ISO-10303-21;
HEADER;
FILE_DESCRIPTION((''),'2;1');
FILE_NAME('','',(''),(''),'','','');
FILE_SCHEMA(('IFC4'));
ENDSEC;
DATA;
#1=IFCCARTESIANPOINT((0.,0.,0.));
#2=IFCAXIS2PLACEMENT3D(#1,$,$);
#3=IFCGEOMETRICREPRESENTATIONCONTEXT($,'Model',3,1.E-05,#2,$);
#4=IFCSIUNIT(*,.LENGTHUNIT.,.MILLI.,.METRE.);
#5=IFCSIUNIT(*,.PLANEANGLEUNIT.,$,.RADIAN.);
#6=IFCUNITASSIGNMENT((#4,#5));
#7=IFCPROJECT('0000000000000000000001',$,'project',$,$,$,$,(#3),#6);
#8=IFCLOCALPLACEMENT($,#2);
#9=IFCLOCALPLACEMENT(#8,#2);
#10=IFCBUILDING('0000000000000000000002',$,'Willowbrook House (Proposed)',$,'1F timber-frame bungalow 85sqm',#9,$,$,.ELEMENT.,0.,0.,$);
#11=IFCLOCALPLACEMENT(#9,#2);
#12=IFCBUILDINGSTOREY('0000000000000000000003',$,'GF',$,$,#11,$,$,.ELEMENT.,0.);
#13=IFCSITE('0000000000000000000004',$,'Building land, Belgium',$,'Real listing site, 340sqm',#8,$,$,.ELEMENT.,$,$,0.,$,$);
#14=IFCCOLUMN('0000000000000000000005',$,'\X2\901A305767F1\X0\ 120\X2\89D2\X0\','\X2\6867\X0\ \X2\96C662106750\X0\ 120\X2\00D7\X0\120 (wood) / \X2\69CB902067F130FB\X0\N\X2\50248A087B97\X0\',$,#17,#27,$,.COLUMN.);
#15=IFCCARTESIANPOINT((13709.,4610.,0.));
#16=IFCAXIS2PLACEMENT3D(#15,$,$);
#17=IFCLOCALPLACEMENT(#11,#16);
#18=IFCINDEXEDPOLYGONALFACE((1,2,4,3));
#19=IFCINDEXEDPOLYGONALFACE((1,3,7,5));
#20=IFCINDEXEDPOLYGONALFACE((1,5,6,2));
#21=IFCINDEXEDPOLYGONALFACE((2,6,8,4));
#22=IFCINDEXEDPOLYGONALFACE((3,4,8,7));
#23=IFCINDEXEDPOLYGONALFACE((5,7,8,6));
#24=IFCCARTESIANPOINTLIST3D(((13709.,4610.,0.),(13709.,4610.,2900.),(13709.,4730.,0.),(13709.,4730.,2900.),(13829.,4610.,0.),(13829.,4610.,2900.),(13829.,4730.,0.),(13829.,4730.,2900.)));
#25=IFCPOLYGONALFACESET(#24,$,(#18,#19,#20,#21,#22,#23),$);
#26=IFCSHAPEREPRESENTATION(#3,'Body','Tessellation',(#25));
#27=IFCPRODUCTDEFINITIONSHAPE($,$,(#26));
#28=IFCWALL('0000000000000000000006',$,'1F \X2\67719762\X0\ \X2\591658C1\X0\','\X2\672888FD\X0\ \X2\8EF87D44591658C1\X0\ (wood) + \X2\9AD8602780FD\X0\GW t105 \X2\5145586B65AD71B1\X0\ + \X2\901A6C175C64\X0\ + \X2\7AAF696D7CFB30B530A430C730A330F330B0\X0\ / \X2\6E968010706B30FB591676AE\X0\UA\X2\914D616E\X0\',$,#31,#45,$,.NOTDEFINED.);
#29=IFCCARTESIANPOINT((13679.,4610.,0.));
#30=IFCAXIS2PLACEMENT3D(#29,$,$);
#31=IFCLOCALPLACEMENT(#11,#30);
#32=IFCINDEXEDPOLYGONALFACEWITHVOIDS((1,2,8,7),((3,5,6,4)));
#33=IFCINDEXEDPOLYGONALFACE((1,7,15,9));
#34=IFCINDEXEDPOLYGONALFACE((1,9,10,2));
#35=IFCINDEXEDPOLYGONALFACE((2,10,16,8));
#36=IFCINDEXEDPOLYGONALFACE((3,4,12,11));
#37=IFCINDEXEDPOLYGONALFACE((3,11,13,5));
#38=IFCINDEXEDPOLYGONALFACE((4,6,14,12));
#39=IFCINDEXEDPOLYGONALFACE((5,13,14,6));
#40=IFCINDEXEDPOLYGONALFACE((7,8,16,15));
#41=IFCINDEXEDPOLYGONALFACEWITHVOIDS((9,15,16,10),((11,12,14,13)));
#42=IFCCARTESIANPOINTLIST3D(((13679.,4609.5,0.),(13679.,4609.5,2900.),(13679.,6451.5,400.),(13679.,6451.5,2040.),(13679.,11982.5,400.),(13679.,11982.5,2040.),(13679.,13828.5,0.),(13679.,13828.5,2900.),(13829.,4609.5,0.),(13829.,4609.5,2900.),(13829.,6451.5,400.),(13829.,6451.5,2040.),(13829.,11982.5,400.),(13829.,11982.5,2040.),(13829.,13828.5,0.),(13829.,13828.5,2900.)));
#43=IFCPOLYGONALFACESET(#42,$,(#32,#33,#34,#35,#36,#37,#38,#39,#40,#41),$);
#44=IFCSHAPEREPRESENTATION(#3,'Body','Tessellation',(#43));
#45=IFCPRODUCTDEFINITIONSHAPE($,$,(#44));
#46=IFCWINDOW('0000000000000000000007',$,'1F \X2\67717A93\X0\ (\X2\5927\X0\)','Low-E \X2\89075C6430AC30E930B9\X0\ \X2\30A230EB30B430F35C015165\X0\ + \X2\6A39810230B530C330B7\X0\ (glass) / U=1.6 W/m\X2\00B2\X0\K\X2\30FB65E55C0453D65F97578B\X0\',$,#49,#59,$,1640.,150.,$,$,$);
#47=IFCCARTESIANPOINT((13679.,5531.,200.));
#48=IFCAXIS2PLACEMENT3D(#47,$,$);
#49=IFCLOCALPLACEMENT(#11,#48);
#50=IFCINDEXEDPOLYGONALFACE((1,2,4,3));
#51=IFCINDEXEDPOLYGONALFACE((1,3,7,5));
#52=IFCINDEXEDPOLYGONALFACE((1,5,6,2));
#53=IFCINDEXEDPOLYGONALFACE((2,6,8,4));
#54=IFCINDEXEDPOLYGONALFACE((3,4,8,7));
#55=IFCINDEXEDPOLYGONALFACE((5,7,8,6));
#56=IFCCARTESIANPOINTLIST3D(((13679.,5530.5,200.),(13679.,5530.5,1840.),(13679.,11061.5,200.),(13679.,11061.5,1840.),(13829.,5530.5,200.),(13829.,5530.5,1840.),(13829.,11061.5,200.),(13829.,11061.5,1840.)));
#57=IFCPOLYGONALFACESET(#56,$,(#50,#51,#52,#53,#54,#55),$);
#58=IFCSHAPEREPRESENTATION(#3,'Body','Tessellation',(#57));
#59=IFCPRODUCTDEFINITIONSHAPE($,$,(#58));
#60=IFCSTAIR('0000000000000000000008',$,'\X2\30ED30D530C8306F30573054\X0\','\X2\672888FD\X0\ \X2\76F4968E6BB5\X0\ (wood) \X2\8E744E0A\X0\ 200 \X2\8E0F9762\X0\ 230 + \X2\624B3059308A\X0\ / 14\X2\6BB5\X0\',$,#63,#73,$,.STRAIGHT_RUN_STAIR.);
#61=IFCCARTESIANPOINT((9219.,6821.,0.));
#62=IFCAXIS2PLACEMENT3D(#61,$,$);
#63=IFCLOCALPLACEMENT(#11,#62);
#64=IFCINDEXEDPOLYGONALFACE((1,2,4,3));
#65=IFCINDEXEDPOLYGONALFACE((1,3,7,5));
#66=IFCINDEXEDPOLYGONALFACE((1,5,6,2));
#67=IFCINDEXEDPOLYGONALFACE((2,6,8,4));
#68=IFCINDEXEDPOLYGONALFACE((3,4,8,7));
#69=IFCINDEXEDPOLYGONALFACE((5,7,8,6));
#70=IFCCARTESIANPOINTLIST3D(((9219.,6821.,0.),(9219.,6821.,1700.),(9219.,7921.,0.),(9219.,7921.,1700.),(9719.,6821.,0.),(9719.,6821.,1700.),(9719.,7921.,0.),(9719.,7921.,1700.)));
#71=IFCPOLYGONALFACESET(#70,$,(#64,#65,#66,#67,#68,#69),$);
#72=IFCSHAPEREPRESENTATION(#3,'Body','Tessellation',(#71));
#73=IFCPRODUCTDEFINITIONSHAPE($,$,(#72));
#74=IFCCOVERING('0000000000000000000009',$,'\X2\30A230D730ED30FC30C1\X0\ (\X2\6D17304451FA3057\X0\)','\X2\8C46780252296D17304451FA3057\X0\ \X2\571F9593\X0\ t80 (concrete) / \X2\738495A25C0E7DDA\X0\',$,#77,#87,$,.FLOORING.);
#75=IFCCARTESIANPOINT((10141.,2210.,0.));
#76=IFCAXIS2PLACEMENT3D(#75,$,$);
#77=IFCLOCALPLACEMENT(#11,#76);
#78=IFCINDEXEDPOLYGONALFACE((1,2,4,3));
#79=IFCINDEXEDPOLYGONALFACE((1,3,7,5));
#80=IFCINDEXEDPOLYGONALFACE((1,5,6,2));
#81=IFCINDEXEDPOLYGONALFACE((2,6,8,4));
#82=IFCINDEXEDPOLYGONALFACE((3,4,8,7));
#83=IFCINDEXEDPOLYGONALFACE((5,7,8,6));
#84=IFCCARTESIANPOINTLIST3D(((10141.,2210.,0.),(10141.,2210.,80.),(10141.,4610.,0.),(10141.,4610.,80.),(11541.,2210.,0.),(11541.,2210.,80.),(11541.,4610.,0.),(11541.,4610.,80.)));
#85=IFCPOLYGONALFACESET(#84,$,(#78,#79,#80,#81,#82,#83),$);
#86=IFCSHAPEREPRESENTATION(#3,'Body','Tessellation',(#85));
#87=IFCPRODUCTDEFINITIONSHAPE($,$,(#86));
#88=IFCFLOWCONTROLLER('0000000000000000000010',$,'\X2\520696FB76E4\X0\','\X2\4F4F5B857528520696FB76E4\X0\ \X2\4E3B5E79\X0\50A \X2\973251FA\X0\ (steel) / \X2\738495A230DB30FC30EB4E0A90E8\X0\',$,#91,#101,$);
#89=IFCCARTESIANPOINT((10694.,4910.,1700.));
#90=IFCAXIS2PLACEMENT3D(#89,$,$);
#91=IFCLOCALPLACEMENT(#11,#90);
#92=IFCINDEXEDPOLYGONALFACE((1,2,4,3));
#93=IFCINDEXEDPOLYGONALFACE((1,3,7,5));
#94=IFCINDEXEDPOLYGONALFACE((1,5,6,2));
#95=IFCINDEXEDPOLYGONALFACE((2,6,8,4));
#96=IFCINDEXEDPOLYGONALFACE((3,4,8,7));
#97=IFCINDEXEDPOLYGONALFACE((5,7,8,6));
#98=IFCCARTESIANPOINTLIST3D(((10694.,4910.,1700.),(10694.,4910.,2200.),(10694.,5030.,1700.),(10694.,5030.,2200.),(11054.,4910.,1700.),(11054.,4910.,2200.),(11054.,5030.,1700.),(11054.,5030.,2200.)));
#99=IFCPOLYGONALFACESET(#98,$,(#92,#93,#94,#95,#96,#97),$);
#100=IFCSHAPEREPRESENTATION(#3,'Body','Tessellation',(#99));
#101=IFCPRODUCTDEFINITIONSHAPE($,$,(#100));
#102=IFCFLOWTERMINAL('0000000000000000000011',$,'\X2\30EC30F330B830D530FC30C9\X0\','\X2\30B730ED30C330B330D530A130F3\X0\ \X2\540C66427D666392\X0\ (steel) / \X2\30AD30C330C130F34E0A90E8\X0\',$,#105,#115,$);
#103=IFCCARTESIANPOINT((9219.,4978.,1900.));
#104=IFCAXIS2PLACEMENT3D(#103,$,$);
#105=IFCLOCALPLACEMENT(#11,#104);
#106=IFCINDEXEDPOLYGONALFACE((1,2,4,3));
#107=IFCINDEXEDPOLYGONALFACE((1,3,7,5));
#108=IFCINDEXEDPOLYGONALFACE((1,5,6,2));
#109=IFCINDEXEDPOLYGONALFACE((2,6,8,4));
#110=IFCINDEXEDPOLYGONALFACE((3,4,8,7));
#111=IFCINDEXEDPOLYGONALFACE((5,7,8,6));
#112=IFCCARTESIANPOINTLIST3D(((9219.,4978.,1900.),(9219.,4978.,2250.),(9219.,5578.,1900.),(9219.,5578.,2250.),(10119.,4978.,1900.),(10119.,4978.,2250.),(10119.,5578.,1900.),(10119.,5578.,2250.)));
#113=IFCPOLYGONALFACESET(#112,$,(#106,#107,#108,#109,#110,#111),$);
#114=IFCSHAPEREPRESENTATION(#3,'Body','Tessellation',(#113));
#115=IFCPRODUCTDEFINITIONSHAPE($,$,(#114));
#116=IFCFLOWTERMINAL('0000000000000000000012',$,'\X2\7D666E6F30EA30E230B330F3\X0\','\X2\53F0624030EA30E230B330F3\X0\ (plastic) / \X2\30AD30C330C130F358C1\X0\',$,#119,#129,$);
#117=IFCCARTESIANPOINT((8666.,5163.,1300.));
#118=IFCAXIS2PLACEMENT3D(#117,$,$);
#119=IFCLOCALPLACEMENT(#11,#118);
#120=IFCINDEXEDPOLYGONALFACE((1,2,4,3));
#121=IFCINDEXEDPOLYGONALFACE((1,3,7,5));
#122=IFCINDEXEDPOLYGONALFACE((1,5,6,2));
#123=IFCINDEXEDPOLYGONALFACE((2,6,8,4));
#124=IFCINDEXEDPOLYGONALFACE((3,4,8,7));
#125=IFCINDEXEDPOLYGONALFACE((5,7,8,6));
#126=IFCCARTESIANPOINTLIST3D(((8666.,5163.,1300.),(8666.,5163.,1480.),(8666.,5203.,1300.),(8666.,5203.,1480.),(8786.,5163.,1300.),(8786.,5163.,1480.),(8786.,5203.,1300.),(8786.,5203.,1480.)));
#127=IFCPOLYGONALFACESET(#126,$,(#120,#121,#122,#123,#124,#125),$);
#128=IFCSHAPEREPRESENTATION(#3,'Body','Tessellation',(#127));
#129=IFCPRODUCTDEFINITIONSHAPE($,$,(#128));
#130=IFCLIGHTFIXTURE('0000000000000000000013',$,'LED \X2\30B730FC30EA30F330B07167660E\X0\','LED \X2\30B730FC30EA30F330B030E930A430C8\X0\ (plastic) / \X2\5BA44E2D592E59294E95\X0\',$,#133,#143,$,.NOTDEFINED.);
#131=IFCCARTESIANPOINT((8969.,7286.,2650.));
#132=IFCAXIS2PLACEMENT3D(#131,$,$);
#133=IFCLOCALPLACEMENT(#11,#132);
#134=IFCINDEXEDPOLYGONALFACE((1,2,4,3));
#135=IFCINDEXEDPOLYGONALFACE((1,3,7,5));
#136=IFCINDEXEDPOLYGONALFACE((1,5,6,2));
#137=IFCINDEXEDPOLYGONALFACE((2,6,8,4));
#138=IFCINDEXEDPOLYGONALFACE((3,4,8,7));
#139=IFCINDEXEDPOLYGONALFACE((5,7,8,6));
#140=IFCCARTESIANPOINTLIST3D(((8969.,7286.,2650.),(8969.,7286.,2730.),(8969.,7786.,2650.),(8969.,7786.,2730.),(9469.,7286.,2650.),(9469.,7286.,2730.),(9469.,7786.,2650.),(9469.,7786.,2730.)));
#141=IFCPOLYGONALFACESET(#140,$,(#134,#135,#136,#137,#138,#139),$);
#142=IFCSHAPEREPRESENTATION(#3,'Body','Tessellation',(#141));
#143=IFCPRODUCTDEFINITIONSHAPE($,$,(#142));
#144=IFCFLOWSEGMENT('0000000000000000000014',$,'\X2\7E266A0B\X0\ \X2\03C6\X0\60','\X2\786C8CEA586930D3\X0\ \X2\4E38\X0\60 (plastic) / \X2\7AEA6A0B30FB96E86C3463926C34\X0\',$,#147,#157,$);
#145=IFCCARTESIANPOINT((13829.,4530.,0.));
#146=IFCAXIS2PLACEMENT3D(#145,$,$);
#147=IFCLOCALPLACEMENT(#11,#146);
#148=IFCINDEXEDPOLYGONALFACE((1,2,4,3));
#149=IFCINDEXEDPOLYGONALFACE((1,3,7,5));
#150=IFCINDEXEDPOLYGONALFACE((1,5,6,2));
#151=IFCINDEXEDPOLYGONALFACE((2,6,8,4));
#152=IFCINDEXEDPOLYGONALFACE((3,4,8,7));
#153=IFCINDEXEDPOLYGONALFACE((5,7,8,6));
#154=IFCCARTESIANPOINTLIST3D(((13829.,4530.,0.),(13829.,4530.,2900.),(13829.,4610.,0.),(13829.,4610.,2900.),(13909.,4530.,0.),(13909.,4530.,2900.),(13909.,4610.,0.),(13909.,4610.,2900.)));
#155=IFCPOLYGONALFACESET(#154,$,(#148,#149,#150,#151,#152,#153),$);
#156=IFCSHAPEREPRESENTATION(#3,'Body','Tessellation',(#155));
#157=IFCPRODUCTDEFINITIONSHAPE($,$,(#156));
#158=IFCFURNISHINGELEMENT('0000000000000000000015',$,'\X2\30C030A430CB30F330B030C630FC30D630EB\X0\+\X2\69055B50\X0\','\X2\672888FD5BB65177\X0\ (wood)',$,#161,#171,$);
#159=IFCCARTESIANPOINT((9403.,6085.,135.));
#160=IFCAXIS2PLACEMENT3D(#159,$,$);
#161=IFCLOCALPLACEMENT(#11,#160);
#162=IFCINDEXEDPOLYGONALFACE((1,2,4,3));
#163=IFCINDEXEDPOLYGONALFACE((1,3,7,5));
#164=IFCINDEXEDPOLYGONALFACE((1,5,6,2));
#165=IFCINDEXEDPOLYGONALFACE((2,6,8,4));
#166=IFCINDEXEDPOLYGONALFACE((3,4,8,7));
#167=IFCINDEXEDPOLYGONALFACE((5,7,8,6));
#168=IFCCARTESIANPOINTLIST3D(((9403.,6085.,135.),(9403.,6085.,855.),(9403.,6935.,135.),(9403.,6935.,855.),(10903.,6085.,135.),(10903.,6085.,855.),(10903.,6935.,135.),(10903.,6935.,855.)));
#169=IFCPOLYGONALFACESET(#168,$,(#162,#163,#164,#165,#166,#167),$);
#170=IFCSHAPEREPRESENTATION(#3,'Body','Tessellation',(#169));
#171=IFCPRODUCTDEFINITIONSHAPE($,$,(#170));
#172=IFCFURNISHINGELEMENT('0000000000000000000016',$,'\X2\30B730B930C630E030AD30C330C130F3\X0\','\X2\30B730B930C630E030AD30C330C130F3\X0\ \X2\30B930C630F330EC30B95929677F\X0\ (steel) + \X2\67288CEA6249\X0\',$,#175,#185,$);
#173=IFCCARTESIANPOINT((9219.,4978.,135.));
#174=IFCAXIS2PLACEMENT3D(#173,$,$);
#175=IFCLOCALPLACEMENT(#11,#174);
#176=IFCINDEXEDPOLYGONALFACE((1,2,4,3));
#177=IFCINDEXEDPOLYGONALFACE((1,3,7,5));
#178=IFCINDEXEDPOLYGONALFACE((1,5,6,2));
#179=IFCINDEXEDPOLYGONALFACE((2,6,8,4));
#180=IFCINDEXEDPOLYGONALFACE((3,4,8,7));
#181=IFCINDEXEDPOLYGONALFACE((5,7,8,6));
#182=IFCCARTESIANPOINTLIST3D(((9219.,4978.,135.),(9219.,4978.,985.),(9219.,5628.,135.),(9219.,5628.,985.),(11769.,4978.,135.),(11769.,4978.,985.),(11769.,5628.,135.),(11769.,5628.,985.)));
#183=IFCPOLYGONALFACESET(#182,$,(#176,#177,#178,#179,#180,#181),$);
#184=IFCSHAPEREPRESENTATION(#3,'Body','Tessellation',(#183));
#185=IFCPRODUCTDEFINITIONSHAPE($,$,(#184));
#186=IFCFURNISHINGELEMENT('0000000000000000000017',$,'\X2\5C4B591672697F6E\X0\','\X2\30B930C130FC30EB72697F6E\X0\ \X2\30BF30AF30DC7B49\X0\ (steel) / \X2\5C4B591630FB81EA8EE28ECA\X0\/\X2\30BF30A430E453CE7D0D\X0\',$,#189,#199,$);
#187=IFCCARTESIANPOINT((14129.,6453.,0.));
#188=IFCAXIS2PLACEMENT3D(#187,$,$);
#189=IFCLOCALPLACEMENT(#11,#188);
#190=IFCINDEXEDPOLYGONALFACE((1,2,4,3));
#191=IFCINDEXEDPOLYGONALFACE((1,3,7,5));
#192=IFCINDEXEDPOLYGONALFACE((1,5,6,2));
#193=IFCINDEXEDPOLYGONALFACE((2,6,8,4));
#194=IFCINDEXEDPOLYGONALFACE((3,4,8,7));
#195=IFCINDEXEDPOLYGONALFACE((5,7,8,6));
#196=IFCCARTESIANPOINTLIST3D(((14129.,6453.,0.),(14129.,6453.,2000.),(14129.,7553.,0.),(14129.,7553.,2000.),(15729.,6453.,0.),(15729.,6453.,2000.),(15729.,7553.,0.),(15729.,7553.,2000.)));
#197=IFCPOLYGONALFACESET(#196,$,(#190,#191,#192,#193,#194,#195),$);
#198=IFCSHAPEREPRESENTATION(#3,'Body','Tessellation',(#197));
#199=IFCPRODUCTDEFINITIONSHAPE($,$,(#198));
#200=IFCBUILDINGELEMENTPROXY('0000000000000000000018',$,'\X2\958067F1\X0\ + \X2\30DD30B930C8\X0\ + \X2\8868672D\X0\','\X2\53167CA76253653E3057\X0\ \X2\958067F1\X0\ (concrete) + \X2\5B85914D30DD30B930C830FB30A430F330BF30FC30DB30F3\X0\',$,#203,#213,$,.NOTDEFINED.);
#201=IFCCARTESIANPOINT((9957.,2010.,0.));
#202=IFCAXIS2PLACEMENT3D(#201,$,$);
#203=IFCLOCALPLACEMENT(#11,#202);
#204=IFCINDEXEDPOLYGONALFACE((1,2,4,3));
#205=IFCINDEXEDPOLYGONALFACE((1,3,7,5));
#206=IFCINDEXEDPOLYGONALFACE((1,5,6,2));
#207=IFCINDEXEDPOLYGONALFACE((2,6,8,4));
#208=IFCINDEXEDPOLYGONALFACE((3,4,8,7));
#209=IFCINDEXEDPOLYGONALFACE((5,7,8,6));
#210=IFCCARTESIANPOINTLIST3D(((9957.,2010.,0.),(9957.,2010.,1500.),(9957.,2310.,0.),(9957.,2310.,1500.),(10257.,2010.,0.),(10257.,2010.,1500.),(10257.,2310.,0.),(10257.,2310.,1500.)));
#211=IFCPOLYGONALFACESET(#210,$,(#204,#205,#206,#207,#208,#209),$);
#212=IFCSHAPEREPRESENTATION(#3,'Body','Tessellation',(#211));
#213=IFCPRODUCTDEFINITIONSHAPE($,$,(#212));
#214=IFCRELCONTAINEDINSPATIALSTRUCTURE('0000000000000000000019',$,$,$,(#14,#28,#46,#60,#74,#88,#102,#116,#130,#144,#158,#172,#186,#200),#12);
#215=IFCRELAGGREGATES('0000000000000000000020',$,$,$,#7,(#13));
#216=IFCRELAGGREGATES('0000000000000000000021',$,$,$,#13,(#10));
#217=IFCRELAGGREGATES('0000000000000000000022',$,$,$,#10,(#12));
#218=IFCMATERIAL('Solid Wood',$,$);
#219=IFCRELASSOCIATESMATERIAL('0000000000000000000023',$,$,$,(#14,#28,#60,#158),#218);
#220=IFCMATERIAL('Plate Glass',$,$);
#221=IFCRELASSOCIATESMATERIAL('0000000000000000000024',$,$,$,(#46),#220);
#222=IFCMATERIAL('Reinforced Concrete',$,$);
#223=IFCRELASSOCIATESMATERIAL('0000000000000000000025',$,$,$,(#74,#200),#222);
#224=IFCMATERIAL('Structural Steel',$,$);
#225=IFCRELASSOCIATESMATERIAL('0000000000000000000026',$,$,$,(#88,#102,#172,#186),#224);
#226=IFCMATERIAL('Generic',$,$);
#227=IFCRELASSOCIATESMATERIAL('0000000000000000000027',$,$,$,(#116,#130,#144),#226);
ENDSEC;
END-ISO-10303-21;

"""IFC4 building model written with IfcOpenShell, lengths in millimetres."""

from ifc_helpers import new_model, si_unit, frame, frame_2d, origin, place, context, project, spatial, rectangle, extrude, material, element, fill, save


model = new_model("IFC4")

# Units and contexts
model_context = context("Model", 3, precision=1e-05, world=origin())
ifc_project = project(units=[si_unit("LENGTHUNIT", "METRE", prefix="MILLI"), si_unit("PLANEANGLEUNIT", "RADIAN")], contexts=[model_context])

# Site, building, storey
site_placement = place(None, origin())
site = spatial("IfcSite", under=ifc_project, at=site_placement, Name="Building land, Belgium", ObjectType="Real listing site, 340sqm", CompositionType="ELEMENT", RefElevation=0.0)
building_placement = place(site_placement, origin())
building = spatial("IfcBuilding", under=site, at=building_placement, Name="Willowbrook House (Proposed)", ObjectType="1F timber-frame bungalow 85sqm", CompositionType="ELEMENT", ElevationOfRefHeight=0.0, ElevationOfTerrain=0.0)
storey_placement = place(building_placement, origin())
storey = spatial("IfcBuildingStorey", under=building, at=storey_placement, Name="GF", CompositionType="ELEMENT", Elevation=0.0)

# Column
ifc_material_1 = material(Name="Solid Wood")
column_1_placement = place(storey_placement, frame((13709.0, 4610.0, 0.0)))
element("IfcColumn", 1, at=column_1_placement, inside=storey, material=ifc_material_1, Name="通し柱 120角", Description="桧 集成材 120×120 (wood) / 構造柱・N値計算", PredefinedType="COLUMN", context=model_context, shape_type="SweptSolid", body=[
    extrude(rectangle(XDim=120.0, YDim=120.0, at=frame_2d((60.0, 60.0))), frame((13709.0, 4610.0, 0.0)), (0.0, 0.0, 1.0), 2900.0),
])

# Wall, opening, window
wall_1_placement = place(storey_placement, frame((13679.0, 4610.0, 0.0)))
wall_1 = element("IfcWall", 2, at=wall_1_placement, inside=storey, material=ifc_material_1, Name="1F 東面 外壁", Description="木製 軸組外壁 (wood) + 高性能GW t105 充填断熱 + 通気層 + 窯業系サイディング / 準耐火・外皮UA配慮", PredefinedType="NOTDEFINED", context=model_context, shape_type="SweptSolid", body=[
    extrude(rectangle(XDim=150.0, YDim=9219.0, at=frame_2d((75.0, 4609.0))), frame((13679.0, 4610.0, 0.0)), (0.0, 0.0, 1.0), 2900.0),
])
opening_placement = place(storey_placement, frame((13679.0, 5531.0, 200.0)))
opening = element("IfcOpeningElement", 3, at=opening_placement, cuts=wall_1, PredefinedType="NOTDEFINED", context=model_context, shape_type="SweptSolid", body=[
    extrude(rectangle(XDim=150.0, YDim=5531.0, at=frame_2d((75.0, 2765.0))), frame((13679.0, 5531.0, 200.0)), (0.0, 0.0, 1.0), 1640.0),
])
ifc_material_2 = material(Name="Plate Glass")
window_placement = place(storey_placement, frame((13679.0, 5531.0, 200.0)))
window = element("IfcWindow", 4, at=window_placement, inside=storey, material=ifc_material_2, Name="1F 東窓 (大)", Description="Low-E 複層ガラス アルゴン封入 + 樹脂サッシ (glass) / U=1.6 W/m²K・日射取得型", OverallHeight=1640.0, OverallWidth=150.0, context=model_context, shape_type="SweptSolid", body=[
    extrude(rectangle(XDim=150.0, YDim=5531.0, at=frame_2d((75.0, 2765.0))), frame((13679.0, 5531.0, 200.0)), (0.0, 0.0, 1.0), 1640.0),
])
fill(opening, window)

# Stair
stair_placement = place(storey_placement, frame((9219.0, 6821.0, 0.0)))
element("IfcStair", 5, at=stair_placement, inside=storey, material=ifc_material_1, Name="ロフトはしご", Description="木製 直階段 (wood) 蹴上 200 踏面 230 + 手すり / 14段", PredefinedType="STRAIGHT_RUN_STAIR", context=model_context, shape_type="SweptSolid", body=[
    extrude(rectangle(XDim=500.0, YDim=1100.0, at=frame_2d((250.0, 550.0))), frame((9219.0, 6821.0, 0.0)), (0.0, 0.0, 1.0), 1700.0),
])

# Covering
ifc_material_3 = material(Name="Reinforced Concrete")
covering_placement = place(storey_placement, frame((10141.0, 2210.0, 0.0)))
element("IfcCovering", 6, at=covering_placement, inside=storey, material=ifc_material_3, Name="アプローチ (洗い出し)", Description="豆砂利洗い出し 土間 t80 (concrete) / 玄関導線", PredefinedType="FLOORING", context=model_context, shape_type="SweptSolid", body=[
    extrude(rectangle(XDim=1400.0, YDim=2400.0, at=frame_2d((700.0, 1200.0))), frame((10141.0, 2210.0, 0.0)), (0.0, 0.0, 1.0), 80.0),
])

# Flow controller
ifc_material_4 = material(Name="Structural Steel")
flow_controller_placement = place(storey_placement, frame((10694.0, 4910.0, 1700.0)))
element("IfcFlowController", 7, at=flow_controller_placement, inside=storey, material=ifc_material_4, Name="分電盤", Description="住宅用分電盤 主幹50A 露出 (steel) / 玄関ホール上部", context=model_context, shape_type="SweptSolid", body=[
    extrude(rectangle(XDim=360.0, YDim=120.0, at=frame_2d((180.0, 60.0))), frame((10694.0, 4910.0, 1700.0)), (0.0, 0.0, 1.0), 500.0),
])

# Flow terminals
flow_terminal_1_placement = place(storey_placement, frame((9219.0, 4978.0, 1900.0)))
element("IfcFlowTerminal", 8, at=flow_terminal_1_placement, inside=storey, material=ifc_material_4, Name="レンジフード", Description="シロッコファン 同時給排 (steel) / キッチン上部", context=model_context, shape_type="SweptSolid", body=[
    extrude(rectangle(XDim=900.0, YDim=600.0, at=frame_2d((450.0, 300.0))), frame((9219.0, 4978.0, 1900.0)), (0.0, 0.0, 1.0), 350.0),
])
ifc_material_5 = material(Name="Generic")
flow_terminal_2_placement = place(storey_placement, frame((8666.0, 5163.0, 1300.0)))
element("IfcFlowTerminal", 9, at=flow_terminal_2_placement, inside=storey, material=ifc_material_5, Name="給湯リモコン", Description="台所リモコン (plastic) / キッチン壁", context=model_context, shape_type="SweptSolid", body=[
    extrude(rectangle(XDim=120.0, YDim=40.0, at=frame_2d((60.0, 20.0))), frame((8666.0, 5163.0, 1300.0)), (0.0, 0.0, 1.0), 180.0),
])

# Light fixture
light_fixture_placement = place(storey_placement, frame((8969.0, 7286.0, 2650.0)))
element("IfcLightFixture", 10, at=light_fixture_placement, inside=storey, material=ifc_material_5, Name="LED シーリング照明", Description="LED シーリングライト (plastic) / 室中央天井", PredefinedType="NOTDEFINED", context=model_context, shape_type="SweptSolid", body=[
    extrude(rectangle(XDim=500.0, YDim=500.0, at=frame_2d((250.0, 250.0))), frame((8969.0, 7286.0, 2650.0)), (0.0, 0.0, 1.0), 80.0),
])

# Flow segment
flow_segment_placement = place(storey_placement, frame((13829.0, 4530.0, 0.0)))
element("IfcFlowSegment", 11, at=flow_segment_placement, inside=storey, material=ifc_material_5, Name="縦樋 φ60", Description="硬質塩ビ 丸60 (plastic) / 竪樋・雨水排水", context=model_context, shape_type="SweptSolid", body=[
    extrude(rectangle(XDim=80.0, YDim=80.0, at=frame_2d((40.0, 40.0))), frame((13829.0, 4530.0, 0.0)), (0.0, 0.0, 1.0), 2900.0),
])

# Furnishing elements
furnishing_1_placement = place(storey_placement, frame((9403.0, 6085.0, 135.0)))
element("IfcFurnishingElement", 12, at=furnishing_1_placement, inside=storey, material=ifc_material_1, Name="ダイニングテーブル+椅子", Description="木製家具 (wood)", context=model_context, shape_type="SweptSolid", body=[
    extrude(rectangle(XDim=1500.0, YDim=850.0, at=frame_2d((750.0, 425.0))), frame((9403.0, 6085.0, 135.0)), (0.0, 0.0, 1.0), 720.0),
])
furnishing_2_placement = place(storey_placement, frame((9219.0, 4978.0, 135.0)))
element("IfcFurnishingElement", 13, at=furnishing_2_placement, inside=storey, material=ifc_material_4, Name="システムキッチン", Description="システムキッチン ステンレス天板 (steel) + 木質扉", context=model_context, shape_type="SweptSolid", body=[
    extrude(rectangle(XDim=2550.0, YDim=650.0, at=frame_2d((1275.0, 325.0))), frame((9219.0, 4978.0, 135.0)), (0.0, 0.0, 1.0), 850.0),
])
furnishing_3_placement = place(storey_placement, frame((14129.0, 6453.0, 0.0)))
element("IfcFurnishingElement", 14, at=furnishing_3_placement, inside=storey, material=ifc_material_4, Name="屋外物置", Description="スチール物置 タクボ等 (steel) / 屋外・自転車/タイヤ収納", context=model_context, shape_type="SweptSolid", body=[
    extrude(rectangle(XDim=1600.0, YDim=1100.0, at=frame_2d((800.0, 550.0))), frame((14129.0, 6453.0, 0.0)), (0.0, 0.0, 1.0), 2000.0),
])

# Building element proxy
proxy_placement = place(storey_placement, frame((9957.0, 2010.0, 0.0)))
element("IfcBuildingElementProxy", 15, at=proxy_placement, inside=storey, material=ifc_material_3, Name="門柱 + ポスト + 表札", Description="化粧打放し 門柱 (concrete) + 宅配ポスト・インターホン", PredefinedType="NOTDEFINED", context=model_context, shape_type="SweptSolid", body=[
    extrude(rectangle(XDim=300.0, YDim=300.0, at=frame_2d((150.0, 150.0))), frame((9957.0, 2010.0, 0.0)), (0.0, 0.0, 1.0), 1500.0),
])

save(model, "model.ifc")
